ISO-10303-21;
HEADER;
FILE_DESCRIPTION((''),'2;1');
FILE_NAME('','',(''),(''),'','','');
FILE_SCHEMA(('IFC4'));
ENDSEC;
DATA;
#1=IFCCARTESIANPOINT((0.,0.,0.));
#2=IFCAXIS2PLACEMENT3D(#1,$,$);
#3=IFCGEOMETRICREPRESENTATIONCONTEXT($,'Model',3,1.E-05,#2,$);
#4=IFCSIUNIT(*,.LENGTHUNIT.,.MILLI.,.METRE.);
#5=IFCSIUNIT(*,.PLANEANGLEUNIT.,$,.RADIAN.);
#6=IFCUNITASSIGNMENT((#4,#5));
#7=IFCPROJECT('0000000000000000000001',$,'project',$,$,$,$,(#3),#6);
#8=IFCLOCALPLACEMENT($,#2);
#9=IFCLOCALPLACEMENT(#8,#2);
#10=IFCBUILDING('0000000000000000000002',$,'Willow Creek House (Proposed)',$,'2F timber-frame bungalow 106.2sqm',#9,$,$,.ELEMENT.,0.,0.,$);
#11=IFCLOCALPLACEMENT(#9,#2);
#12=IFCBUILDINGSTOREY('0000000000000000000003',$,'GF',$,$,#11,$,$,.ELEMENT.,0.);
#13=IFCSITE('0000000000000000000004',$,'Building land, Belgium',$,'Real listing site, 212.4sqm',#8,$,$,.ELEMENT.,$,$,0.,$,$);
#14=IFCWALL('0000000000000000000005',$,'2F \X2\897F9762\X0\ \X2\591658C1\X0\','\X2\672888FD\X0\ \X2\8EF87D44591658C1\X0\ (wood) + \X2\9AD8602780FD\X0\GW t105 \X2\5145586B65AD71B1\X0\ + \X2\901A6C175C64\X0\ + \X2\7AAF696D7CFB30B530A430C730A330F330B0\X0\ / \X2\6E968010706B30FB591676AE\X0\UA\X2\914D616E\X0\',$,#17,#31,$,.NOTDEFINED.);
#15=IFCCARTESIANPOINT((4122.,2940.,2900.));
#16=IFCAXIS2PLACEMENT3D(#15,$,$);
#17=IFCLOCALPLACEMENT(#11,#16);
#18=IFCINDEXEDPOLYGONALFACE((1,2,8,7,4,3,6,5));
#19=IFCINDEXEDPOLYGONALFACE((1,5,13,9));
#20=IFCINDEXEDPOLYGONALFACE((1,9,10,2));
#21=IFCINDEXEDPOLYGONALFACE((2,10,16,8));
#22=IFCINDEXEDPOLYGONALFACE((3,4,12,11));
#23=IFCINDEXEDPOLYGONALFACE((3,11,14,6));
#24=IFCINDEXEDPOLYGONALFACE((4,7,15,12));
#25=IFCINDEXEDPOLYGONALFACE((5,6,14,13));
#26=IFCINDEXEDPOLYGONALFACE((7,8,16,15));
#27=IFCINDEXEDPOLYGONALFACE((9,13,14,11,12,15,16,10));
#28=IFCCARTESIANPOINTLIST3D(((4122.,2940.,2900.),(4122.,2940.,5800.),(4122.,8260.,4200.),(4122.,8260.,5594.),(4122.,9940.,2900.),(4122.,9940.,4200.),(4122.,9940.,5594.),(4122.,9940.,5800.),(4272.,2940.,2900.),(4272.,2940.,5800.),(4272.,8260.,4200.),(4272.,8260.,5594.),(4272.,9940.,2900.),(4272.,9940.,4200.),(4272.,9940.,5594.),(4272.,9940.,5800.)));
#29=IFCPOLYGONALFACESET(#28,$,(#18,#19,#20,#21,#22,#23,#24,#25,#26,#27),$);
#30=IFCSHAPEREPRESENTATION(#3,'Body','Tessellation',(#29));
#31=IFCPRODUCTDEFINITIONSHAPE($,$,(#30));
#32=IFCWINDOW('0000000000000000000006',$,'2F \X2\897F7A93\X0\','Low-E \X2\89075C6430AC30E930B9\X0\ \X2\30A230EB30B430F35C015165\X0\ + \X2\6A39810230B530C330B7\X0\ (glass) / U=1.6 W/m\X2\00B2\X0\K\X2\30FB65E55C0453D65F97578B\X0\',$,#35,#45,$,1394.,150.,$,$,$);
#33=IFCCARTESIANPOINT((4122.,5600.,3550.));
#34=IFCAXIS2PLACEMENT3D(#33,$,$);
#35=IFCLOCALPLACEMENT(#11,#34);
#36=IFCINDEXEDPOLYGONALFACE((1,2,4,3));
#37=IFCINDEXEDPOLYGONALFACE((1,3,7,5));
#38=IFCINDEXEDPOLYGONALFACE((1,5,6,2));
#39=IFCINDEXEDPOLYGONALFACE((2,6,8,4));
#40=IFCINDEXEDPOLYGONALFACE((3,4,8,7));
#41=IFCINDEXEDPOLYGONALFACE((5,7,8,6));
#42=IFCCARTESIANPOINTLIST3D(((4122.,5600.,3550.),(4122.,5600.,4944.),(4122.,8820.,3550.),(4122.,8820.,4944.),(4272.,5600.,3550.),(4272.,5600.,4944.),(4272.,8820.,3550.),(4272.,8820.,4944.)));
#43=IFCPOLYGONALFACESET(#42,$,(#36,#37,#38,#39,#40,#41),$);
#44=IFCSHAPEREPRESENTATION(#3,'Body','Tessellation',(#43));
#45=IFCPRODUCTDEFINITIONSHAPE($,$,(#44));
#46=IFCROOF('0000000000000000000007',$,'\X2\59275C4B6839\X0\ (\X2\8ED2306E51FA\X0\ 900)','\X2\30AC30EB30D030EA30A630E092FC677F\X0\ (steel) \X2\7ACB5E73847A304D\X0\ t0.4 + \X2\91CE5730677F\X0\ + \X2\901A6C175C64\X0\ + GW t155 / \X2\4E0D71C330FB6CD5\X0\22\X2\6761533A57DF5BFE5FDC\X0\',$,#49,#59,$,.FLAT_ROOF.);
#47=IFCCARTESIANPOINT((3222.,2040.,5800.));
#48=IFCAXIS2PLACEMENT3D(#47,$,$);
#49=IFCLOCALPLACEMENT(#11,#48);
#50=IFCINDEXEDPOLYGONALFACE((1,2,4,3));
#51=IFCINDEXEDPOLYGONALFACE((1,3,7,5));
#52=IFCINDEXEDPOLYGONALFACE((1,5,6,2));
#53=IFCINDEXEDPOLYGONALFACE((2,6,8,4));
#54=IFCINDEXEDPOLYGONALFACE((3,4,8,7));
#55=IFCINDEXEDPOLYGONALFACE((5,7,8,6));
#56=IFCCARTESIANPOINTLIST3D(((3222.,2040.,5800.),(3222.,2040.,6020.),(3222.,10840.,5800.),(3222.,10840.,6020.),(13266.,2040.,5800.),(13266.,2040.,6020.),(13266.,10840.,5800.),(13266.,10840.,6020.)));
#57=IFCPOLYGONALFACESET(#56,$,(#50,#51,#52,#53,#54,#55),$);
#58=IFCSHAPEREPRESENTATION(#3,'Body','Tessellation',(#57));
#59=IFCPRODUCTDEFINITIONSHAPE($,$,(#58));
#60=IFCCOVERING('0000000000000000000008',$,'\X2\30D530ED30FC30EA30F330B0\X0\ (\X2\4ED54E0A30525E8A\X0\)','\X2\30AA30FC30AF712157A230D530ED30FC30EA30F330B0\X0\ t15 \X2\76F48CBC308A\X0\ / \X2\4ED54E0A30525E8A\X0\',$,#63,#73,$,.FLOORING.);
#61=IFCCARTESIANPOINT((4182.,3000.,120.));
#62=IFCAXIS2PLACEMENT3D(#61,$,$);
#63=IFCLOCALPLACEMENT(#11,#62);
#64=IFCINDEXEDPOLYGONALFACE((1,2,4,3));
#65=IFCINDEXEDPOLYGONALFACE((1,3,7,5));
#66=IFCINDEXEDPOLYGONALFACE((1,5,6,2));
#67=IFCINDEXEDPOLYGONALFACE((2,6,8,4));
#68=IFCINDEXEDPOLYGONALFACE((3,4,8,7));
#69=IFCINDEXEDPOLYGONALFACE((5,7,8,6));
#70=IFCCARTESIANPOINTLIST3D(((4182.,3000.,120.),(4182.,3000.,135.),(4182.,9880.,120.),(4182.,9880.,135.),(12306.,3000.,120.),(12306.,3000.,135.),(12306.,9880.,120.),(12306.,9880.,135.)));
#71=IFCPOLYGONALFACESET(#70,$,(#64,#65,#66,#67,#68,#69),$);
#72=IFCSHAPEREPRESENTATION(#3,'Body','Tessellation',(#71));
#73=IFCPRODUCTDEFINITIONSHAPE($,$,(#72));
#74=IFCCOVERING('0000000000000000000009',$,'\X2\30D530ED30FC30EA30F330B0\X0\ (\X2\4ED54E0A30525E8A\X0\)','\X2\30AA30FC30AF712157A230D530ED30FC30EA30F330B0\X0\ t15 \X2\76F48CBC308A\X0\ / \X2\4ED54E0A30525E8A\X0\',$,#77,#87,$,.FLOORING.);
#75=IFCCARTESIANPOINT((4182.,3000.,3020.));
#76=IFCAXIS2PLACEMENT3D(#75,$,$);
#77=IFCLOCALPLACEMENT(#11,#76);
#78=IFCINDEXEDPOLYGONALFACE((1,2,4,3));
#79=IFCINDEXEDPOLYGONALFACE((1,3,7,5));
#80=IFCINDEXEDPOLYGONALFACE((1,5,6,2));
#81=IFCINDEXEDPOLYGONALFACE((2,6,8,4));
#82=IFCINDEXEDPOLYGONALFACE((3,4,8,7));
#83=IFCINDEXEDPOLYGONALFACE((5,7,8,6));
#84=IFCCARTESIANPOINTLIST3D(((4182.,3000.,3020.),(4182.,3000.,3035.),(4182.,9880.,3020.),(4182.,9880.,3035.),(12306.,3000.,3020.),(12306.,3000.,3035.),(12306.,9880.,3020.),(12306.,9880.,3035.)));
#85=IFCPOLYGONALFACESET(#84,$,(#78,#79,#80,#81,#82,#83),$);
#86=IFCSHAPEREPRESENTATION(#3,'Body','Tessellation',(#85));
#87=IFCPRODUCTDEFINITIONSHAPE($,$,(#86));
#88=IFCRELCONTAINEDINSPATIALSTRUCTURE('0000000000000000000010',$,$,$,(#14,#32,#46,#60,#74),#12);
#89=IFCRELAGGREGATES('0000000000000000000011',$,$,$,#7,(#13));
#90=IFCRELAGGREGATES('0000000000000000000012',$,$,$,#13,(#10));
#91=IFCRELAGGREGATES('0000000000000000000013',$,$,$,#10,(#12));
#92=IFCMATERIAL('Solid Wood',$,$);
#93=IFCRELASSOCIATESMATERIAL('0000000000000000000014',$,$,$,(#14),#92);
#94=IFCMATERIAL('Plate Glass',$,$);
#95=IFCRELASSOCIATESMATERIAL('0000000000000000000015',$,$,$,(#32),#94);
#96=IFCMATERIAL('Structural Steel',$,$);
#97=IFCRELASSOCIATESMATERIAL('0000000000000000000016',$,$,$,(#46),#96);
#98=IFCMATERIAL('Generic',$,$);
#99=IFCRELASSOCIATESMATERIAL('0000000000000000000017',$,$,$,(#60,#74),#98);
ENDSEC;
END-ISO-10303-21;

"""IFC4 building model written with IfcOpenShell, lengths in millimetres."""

from ifc_helpers import new_model, si_unit, frame, frame_2d, origin, place, context, project, spatial, rectangle, extrude, material, element, fill, save


model = new_model("IFC4")

# Units and contexts
model_context = context("Model", 3, precision=1e-05, world=origin())
ifc_project = project(units=[si_unit("LENGTHUNIT", "METRE", prefix="MILLI"), si_unit("PLANEANGLEUNIT", "RADIAN")], contexts=[model_context])

# Site, building, storey
site_placement = place(None, origin())
site = spatial("IfcSite", under=ifc_project, at=site_placement, Name="Building land, Belgium", ObjectType="Real listing site, 212.4sqm", CompositionType="ELEMENT", RefElevation=0.0)
building_placement = place(site_placement, origin())
building = spatial("IfcBuilding", under=site, at=building_placement, Name="Willow Creek House (Proposed)", ObjectType="2F timber-frame bungalow 106.2sqm", CompositionType="ELEMENT", ElevationOfRefHeight=0.0, ElevationOfTerrain=0.0)
storey_placement = place(building_placement, origin())
storey = spatial("IfcBuildingStorey", under=building, at=storey_placement, Name="GF", CompositionType="ELEMENT", Elevation=0.0)

# Shared definitions
ifc_material_1 = material(Name="Solid Wood")

# Shared definitions
ifc_material_2 = material(Name="Plate Glass")

# Wall, opening, window
wall_1_placement = place(storey_placement, frame((4122.0, 2940.0, 2900.0)))
wall_1 = element("IfcWall", 1, at=wall_1_placement, inside=storey, material=ifc_material_1, Name="2F 西面 外壁", Description="木製 軸組外壁 (wood) + 高性能GW t105 充填断熱 + 通気層 + 窯業系サイディング / 準耐火・外皮UA配慮", PredefinedType="NOTDEFINED", context=model_context, shape_type="SweptSolid", body=[
    extrude(rectangle(XDim=150.0, YDim=7000.0, at=frame_2d((75.0, 3500.0))), frame((4122.0, 2940.0, 2900.0)), (0.0, 0.0, 1.0), 2900.0),
])
opening_1_placement = place(storey_placement, frame((4122.0, 5600.0, 3550.0)))
opening_1 = element("IfcOpeningElement", 2, at=opening_1_placement, cuts=wall_1, PredefinedType="NOTDEFINED", context=model_context, shape_type="SweptSolid", body=[
    extrude(rectangle(XDim=150.0, YDim=3220.0, at=frame_2d((75.0, 1610.0))), frame((4122.0, 5600.0, 3550.0)), (0.0, 0.0, 1.0), 1394.0),
])
window_1_placement = place(storey_placement, frame((4122.0, 5600.0, 3550.0)))
window_1 = element("IfcWindow", 3, at=window_1_placement, inside=storey, material=ifc_material_2, Name="2F 西窓", Description="Low-E 複層ガラス アルゴン封入 + 樹脂サッシ (glass) / U=1.6 W/m²K・日射取得型", OverallHeight=1394.0, OverallWidth=150.0, context=model_context, shape_type="SweptSolid", body=[
    extrude(rectangle(XDim=150.0, YDim=3220.0, at=frame_2d((75.0, 1610.0))), frame((4122.0, 5600.0, 3550.0)), (0.0, 0.0, 1.0), 1394.0),
])
fill(opening_1, window_1)

# Roof
ifc_material_3 = material(Name="Structural Steel")
roof_placement = place(storey_placement, frame((3222.0, 2040.0, 5800.0)))
element("IfcRoof", 4, at=roof_placement, inside=storey, material=ifc_material_3, Name="大屋根 (軒の出 900)", Description="ガルバリウム鋼板 (steel) 立平葺き t0.4 + 野地板 + 通気層 + GW t155 / 不燃・法22条区域対応", PredefinedType="FLAT_ROOF", context=model_context, shape_type="SweptSolid", body=[
    extrude(rectangle(XDim=10044.0, YDim=8800.0, at=frame_2d((5022.0, 4400.0))), frame((3222.0, 2040.0, 5800.0)), (0.0, 0.0, 1.0), 220.0),
])

# Coverings
ifc_material_4 = material(Name="Generic")
covering_1_placement = place(storey_placement, frame((4182.0, 3000.0, 120.0)))
element("IfcCovering", 5, at=covering_1_placement, inside=storey, material=ifc_material_4, Name="フローリング (仕上げ床)", Description="オーク無垢フローリング t15 直貼り / 仕上げ床", PredefinedType="FLOORING", context=model_context, shape_type="SweptSolid", body=[
    extrude(rectangle(XDim=8124.0, YDim=6880.0, at=frame_2d((4062.0, 3440.0))), frame((4182.0, 3000.0, 120.0)), (0.0, 0.0, 1.0), 15.0),
])
covering_2_placement = place(storey_placement, frame((4182.0, 3000.0, 3020.0)))
element("IfcCovering", 6, at=covering_2_placement, inside=storey, material=ifc_material_4, Name="フローリング (仕上げ床)", Description="オーク無垢フローリング t15 直貼り / 仕上げ床", PredefinedType="FLOORING", context=model_context, shape_type="SweptSolid", body=[
    extrude(rectangle(XDim=8124.0, YDim=6880.0, at=frame_2d((4062.0, 3440.0))), frame((4182.0, 3000.0, 3020.0)), (0.0, 0.0, 1.0), 15.0),
])

save(model, "model.ifc")
